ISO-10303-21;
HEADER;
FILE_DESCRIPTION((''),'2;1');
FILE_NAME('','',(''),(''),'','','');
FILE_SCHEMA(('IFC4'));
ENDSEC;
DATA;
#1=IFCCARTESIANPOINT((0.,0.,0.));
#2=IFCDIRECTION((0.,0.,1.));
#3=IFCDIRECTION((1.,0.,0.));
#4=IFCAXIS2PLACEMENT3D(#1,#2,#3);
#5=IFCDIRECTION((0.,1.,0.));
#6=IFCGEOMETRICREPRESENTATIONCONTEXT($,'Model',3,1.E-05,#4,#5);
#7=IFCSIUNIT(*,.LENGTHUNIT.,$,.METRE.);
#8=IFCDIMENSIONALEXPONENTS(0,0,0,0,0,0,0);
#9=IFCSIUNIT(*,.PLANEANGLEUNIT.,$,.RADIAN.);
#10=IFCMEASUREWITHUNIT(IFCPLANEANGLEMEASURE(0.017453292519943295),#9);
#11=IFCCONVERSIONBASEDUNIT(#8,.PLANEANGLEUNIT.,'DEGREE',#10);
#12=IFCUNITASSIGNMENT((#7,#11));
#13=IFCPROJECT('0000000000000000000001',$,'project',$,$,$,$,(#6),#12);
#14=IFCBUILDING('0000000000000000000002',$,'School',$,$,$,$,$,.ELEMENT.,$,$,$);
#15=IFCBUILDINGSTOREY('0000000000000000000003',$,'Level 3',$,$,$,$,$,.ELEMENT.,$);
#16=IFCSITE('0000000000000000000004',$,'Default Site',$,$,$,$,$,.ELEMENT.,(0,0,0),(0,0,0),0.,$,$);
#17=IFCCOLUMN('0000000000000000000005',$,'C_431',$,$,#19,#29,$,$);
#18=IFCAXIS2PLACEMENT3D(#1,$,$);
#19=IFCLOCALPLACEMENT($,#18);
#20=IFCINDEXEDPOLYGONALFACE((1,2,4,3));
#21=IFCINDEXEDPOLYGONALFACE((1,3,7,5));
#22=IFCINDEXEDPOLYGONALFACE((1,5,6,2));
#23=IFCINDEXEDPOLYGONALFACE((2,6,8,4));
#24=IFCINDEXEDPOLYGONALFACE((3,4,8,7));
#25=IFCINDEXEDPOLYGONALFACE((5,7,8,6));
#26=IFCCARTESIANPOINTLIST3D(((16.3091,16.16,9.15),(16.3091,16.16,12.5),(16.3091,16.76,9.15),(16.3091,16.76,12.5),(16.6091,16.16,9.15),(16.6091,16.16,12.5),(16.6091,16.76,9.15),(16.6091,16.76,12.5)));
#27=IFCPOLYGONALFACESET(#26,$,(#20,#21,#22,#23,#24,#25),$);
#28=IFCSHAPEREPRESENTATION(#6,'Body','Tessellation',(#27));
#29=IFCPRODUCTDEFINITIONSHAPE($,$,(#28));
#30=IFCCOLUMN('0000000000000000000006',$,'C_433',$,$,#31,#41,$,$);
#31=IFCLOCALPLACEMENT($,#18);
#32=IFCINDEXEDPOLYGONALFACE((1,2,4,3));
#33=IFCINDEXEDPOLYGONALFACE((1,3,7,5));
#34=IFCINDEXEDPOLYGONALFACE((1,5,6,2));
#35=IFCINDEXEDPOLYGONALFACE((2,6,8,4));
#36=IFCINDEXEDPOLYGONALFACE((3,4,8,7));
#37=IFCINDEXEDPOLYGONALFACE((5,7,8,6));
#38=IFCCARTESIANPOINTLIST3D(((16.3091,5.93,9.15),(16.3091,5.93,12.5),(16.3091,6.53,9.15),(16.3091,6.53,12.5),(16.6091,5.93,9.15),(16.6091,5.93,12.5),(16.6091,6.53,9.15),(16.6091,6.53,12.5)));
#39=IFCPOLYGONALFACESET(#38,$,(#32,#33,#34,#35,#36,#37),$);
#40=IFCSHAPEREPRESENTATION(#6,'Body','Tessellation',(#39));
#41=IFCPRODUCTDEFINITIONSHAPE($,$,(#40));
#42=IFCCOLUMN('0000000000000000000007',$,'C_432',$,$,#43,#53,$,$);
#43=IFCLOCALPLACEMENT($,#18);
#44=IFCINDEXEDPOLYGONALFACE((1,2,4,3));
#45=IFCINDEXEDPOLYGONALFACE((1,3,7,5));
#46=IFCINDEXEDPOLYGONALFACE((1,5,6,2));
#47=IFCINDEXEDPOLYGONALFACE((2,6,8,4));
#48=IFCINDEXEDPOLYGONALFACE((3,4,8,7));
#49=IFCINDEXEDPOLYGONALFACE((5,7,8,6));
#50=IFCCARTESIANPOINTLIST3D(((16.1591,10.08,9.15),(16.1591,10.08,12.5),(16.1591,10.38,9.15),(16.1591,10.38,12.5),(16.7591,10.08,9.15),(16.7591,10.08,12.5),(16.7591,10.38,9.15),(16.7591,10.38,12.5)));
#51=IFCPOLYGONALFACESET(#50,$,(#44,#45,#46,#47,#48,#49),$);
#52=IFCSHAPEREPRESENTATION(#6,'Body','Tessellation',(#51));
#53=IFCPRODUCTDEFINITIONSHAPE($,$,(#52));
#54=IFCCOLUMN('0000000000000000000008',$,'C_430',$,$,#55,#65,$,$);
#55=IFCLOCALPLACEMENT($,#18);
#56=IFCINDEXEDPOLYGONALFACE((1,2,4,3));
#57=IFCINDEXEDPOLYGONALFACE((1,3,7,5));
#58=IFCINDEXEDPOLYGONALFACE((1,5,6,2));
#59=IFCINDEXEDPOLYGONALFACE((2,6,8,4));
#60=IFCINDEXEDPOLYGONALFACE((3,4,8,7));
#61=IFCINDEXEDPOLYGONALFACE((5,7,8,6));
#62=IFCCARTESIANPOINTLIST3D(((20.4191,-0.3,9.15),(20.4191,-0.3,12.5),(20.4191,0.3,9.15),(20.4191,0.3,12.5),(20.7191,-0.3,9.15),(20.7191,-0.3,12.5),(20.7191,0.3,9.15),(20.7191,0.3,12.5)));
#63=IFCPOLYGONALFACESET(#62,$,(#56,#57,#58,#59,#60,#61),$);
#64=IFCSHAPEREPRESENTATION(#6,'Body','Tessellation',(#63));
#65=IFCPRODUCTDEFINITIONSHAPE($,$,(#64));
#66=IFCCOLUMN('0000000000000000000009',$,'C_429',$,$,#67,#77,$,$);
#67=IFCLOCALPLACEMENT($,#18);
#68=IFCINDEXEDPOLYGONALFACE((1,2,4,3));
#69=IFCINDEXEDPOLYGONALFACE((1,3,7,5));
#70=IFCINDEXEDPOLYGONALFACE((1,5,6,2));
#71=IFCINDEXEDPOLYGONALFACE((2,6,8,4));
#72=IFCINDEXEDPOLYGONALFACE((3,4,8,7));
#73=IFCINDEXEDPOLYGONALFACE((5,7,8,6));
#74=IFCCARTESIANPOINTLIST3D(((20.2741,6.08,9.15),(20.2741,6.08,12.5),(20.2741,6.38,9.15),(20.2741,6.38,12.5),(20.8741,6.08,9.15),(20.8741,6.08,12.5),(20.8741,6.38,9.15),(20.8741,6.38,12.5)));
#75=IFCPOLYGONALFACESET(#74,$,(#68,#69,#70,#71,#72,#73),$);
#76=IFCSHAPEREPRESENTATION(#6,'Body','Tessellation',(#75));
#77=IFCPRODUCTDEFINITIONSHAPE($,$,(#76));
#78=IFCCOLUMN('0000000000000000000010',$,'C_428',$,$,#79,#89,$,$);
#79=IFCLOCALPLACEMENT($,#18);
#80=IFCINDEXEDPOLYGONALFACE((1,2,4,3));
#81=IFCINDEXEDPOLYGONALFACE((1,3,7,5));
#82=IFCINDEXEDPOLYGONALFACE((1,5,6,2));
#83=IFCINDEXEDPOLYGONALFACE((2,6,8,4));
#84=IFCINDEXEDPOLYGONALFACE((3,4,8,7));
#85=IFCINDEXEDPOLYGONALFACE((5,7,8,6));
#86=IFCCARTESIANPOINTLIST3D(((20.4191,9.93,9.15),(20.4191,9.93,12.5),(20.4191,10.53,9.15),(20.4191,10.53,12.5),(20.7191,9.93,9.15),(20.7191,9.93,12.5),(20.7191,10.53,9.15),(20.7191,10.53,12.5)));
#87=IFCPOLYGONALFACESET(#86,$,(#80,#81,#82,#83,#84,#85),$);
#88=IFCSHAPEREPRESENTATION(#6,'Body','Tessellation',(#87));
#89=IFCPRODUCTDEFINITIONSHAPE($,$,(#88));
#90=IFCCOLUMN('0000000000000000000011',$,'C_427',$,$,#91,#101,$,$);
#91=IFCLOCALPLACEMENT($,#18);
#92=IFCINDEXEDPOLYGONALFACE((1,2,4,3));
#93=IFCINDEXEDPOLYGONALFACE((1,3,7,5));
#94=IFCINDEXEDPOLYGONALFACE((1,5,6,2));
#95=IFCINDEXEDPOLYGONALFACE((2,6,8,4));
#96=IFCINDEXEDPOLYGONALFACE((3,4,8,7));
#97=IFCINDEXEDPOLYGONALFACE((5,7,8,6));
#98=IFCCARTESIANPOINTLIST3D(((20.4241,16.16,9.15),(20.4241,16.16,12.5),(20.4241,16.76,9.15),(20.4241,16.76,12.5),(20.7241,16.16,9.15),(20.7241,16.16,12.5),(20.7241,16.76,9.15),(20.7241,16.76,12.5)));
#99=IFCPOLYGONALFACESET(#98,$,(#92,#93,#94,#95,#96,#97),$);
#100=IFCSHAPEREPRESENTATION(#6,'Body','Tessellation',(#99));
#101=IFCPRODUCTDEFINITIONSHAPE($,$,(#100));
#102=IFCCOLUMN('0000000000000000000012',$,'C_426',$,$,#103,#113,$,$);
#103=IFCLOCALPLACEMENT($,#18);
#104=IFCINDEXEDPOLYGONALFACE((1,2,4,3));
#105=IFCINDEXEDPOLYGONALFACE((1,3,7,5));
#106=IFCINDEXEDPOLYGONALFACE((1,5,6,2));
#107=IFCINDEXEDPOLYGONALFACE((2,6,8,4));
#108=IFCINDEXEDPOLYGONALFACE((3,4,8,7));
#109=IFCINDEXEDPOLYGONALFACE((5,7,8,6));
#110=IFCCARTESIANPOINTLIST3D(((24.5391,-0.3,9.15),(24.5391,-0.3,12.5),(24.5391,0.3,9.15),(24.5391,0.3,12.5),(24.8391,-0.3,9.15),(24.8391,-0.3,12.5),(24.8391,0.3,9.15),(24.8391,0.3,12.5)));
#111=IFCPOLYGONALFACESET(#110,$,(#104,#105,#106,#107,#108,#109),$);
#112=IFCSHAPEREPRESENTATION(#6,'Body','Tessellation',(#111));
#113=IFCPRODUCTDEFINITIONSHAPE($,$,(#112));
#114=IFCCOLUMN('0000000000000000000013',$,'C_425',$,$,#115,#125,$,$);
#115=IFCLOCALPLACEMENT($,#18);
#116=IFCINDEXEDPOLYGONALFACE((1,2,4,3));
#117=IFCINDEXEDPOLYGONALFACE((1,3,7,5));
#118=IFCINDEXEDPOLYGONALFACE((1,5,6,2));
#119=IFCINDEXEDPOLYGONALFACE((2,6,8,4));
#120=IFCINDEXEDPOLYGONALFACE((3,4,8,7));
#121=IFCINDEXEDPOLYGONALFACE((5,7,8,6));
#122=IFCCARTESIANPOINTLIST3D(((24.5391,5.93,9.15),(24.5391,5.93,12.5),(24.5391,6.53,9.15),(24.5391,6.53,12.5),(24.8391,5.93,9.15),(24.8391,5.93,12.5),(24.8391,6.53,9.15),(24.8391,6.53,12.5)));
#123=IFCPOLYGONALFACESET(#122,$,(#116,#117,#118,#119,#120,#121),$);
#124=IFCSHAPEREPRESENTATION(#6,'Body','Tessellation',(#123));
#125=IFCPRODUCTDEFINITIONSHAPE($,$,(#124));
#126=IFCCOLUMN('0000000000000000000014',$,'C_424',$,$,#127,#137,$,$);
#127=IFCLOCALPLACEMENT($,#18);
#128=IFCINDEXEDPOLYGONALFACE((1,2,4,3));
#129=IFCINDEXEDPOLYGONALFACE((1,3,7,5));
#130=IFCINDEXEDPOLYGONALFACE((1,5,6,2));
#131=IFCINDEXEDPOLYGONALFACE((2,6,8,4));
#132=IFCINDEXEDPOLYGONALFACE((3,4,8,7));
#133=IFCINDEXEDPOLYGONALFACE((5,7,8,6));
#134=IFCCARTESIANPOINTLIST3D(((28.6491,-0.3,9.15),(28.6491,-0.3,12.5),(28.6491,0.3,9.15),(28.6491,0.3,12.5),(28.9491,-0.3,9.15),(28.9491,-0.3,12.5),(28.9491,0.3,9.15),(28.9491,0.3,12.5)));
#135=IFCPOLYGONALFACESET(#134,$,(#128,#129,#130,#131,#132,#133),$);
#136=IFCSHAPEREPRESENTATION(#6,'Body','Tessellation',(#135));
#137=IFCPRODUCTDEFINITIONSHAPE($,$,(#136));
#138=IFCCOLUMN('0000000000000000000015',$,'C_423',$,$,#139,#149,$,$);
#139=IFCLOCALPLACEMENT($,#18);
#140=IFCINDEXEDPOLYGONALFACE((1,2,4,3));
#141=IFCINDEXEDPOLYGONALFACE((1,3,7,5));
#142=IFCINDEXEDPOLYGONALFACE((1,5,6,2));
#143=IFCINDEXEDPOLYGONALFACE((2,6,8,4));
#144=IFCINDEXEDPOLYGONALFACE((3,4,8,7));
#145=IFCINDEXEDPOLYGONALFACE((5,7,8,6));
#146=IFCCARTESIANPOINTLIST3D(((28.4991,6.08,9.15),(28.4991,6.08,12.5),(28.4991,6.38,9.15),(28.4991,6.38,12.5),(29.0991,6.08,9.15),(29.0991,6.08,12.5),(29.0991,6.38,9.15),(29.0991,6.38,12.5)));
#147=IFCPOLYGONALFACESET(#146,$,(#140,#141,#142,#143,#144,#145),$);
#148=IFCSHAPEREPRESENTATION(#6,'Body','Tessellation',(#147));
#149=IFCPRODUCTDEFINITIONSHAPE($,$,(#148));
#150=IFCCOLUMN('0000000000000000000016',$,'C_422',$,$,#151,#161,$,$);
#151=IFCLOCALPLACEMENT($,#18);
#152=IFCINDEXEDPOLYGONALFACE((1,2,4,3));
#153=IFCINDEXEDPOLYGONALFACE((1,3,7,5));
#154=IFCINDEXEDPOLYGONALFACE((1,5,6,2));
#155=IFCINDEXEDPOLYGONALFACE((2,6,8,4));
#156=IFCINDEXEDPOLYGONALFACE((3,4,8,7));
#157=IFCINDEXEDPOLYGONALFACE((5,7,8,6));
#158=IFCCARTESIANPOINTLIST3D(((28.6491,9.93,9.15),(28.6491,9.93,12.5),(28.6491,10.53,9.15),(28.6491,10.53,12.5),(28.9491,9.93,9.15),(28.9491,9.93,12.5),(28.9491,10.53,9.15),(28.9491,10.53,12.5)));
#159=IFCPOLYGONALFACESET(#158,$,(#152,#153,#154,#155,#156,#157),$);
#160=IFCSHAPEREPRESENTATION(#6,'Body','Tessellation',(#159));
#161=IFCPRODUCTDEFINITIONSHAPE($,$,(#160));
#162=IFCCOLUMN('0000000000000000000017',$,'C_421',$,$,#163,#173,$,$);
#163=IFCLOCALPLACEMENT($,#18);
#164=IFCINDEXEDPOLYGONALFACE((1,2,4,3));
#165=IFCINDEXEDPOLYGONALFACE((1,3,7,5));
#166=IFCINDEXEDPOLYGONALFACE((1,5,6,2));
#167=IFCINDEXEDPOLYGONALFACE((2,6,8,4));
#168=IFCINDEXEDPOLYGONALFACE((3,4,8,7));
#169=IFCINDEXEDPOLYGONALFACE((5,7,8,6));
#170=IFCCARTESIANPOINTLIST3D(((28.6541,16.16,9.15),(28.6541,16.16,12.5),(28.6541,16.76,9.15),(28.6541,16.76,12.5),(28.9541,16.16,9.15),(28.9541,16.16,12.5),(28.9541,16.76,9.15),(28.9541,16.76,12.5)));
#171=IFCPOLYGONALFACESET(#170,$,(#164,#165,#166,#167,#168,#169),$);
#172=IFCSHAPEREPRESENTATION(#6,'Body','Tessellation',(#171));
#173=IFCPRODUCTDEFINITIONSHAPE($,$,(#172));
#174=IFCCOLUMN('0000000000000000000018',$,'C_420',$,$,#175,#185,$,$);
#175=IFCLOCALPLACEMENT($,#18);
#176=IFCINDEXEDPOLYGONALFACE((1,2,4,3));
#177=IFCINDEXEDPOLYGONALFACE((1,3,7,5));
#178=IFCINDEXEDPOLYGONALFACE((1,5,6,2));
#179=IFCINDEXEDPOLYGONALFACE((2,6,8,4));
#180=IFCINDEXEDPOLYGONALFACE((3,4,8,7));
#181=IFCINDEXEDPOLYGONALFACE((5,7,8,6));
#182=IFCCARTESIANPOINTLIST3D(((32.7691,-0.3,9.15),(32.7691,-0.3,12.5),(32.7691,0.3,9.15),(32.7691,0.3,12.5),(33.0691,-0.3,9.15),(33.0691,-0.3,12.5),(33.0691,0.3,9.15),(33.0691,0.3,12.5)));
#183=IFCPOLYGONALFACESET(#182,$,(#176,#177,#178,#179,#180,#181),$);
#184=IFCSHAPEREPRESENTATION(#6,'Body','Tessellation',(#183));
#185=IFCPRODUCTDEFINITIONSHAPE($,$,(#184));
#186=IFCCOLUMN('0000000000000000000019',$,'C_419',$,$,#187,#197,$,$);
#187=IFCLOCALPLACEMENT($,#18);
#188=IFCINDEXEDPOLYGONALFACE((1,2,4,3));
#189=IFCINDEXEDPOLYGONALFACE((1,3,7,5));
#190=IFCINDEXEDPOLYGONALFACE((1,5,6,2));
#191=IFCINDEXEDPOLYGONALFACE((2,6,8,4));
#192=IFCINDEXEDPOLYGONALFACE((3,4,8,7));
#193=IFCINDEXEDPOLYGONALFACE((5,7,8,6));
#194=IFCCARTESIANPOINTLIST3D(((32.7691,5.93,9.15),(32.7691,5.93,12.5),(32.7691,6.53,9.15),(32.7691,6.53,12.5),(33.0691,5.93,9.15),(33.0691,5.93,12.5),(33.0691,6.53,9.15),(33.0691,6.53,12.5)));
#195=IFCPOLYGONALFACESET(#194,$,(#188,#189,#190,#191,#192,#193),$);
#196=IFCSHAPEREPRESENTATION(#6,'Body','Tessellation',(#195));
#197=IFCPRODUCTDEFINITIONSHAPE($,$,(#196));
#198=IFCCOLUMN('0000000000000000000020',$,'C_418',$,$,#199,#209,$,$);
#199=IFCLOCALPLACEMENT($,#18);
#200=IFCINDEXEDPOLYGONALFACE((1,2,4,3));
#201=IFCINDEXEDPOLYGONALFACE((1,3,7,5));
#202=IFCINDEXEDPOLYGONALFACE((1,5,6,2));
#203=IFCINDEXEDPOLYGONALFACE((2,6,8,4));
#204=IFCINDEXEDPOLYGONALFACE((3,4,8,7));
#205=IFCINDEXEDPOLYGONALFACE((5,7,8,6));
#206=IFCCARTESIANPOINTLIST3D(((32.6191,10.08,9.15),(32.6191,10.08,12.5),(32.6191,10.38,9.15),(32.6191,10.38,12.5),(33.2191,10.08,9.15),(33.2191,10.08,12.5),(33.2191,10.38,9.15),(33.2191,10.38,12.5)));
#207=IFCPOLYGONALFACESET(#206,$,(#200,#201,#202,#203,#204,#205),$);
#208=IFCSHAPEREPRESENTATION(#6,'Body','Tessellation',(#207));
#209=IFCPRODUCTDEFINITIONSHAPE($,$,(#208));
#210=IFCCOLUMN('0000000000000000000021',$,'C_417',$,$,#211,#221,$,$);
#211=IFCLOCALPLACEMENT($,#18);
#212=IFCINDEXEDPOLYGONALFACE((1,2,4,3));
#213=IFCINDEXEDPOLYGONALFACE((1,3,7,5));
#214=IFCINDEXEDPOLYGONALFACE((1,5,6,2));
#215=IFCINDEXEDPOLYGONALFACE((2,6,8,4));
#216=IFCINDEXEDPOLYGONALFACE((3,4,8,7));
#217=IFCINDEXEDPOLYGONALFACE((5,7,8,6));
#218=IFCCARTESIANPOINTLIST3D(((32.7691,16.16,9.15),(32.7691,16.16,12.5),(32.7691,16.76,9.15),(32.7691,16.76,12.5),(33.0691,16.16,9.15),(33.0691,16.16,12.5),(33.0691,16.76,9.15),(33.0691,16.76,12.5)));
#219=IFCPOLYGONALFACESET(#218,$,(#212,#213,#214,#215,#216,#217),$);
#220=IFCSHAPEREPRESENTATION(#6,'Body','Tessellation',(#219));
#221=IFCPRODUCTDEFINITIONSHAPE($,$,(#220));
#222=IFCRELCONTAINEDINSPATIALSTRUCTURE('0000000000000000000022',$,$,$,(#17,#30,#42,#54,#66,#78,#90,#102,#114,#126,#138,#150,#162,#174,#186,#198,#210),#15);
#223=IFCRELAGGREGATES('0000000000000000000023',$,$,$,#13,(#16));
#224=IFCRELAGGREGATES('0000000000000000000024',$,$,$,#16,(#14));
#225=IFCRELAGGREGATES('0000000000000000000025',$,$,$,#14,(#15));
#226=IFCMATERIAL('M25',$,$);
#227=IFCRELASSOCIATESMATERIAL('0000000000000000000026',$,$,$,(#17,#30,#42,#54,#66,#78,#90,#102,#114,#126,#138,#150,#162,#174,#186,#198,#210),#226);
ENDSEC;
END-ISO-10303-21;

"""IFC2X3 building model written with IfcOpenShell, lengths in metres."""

from ifc_helpers import new_model, entity, si_unit, converted_unit, direction, frame, frame_2d, origin_with_axes, place, context, project, spatial, rectangle, extrude, material, element, save


model = new_model("IFC2X3")

# Units and contexts
model_context = context("Model", 3, precision=1e-05, world=origin_with_axes(), true_north=direction((0.0, 1.0, 0.0)))
ifc_project = project(units=[si_unit("LENGTHUNIT", "METRE"), converted_unit("PLANEANGLEUNIT", "DEGREE", entity("IfcPlaneAngleMeasure", 0.017453292519943295), si_unit("PLANEANGLEUNIT", "RADIAN"), dimensions=[0, 0, 0, 0, 0, 0, 0])], contexts=[model_context])

# Site, building, storey
site = spatial("IfcSite", under=ifc_project, Name="Default Site", CompositionType="ELEMENT", RefLatitude=(0, 0, 0), RefLongitude=(0, 0, 0), RefElevation=0.0)
building = spatial("IfcBuilding", under=site, Name="School", CompositionType="ELEMENT")
storey = spatial("IfcBuildingStorey", under=building, Name="Level 3", CompositionType="ELEMENT")

# Columns
ifc_material = material(Name="M25")
placement = place(None, origin_with_axes())
element("IfcColumn", 1, at=placement, inside=storey, material=ifc_material, Name="C_431", context=model_context, shape_type="SweptSolid", body=[
    extrude(rectangle(XDim=0.3, YDim=0.6, at=frame_2d((0.0, 0.0), x_axis=(1.0, 0.0, 0.0))), frame((16.4591, 16.46, 9.15), z_axis=(0.0, 0.0, 1.0), x_axis=(1.0, 0.0, 0.0)), (0.0, 0.0, 1.0), 3.35),
])
element("IfcColumn", 2, at=placement, inside=storey, material=ifc_material, Name="C_433", context=model_context, shape_type="SweptSolid", body=[
    extrude(rectangle(XDim=0.3, YDim=0.6, at=frame_2d((0.0, 0.0), x_axis=(1.0, 0.0, 0.0))), frame((16.4591, 6.23, 9.15), z_axis=(0.0, 0.0, 1.0), x_axis=(1.0, 0.0, 0.0)), (0.0, 0.0, 1.0), 3.35),
])
element("IfcColumn", 3, at=placement, inside=storey, material=ifc_material, Name="C_432", context=model_context, shape_type="SweptSolid", body=[
    extrude(rectangle(XDim=0.6, YDim=0.3, at=frame_2d((0.0, 0.0), x_axis=(1.0, 0.0, 0.0))), frame((16.4591, 10.23, 9.15), z_axis=(0.0, 0.0, 1.0), x_axis=(1.0, 0.0, 0.0)), (0.0, 0.0, 1.0), 3.35),
])
element("IfcColumn", 4, at=placement, inside=storey, material=ifc_material, Name="C_430", context=model_context, shape_type="SweptSolid", body=[
    extrude(rectangle(XDim=0.3, YDim=0.6, at=frame_2d((0.0, 0.0), x_axis=(1.0, 0.0, 0.0))), frame((20.5691, 0.0, 9.15), z_axis=(0.0, 0.0, 1.0), x_axis=(1.0, 0.0, 0.0)), (0.0, 0.0, 1.0), 3.35),
])
element("IfcColumn", 5, at=placement, inside=storey, material=ifc_material, Name="C_429", context=model_context, shape_type="SweptSolid", body=[
    extrude(rectangle(XDim=0.6, YDim=0.3, at=frame_2d((0.0, 0.0), x_axis=(1.0, 0.0, 0.0))), frame((20.5741, 6.23, 9.15), z_axis=(0.0, 0.0, 1.0), x_axis=(1.0, 0.0, 0.0)), (0.0, 0.0, 1.0), 3.35),
])
element("IfcColumn", 6, at=placement, inside=storey, material=ifc_material, Name="C_428", context=model_context, shape_type="SweptSolid", body=[
    extrude(rectangle(XDim=0.3, YDim=0.6, at=frame_2d((0.0, 0.0), x_axis=(1.0, 0.0, 0.0))), frame((20.5691, 10.23, 9.15), z_axis=(0.0, 0.0, 1.0), x_axis=(1.0, 0.0, 0.0)), (0.0, 0.0, 1.0), 3.35),
])
element("IfcColumn", 7, at=placement, inside=storey, material=ifc_material, Name="C_427", context=model_context, shape_type="SweptSolid", body=[
    extrude(rectangle(XDim=0.3, YDim=0.6, at=frame_2d((0.0, 0.0), x_axis=(1.0, 0.0, 0.0))), frame((20.5741, 16.46, 9.15), z_axis=(0.0, 0.0, 1.0), x_axis=(1.0, 0.0, 0.0)), (0.0, 0.0, 1.0), 3.35),
])
element("IfcColumn", 8, at=placement, inside=storey, material=ifc_material, Name="C_426", context=model_context, shape_type="SweptSolid", body=[
    extrude(rectangle(XDim=0.3, YDim=0.6, at=frame_2d((0.0, 0.0), x_axis=(1.0, 0.0, 0.0))), frame((24.6891, 0.0, 9.15), z_axis=(0.0, 0.0, 1.0), x_axis=(1.0, 0.0, 0.0)), (0.0, 0.0, 1.0), 3.35),
])
element("IfcColumn", 9, at=placement, inside=storey, material=ifc_material, Name="C_425", context=model_context, shape_type="SweptSolid", body=[
    extrude(rectangle(XDim=0.3, YDim=0.6, at=frame_2d((0.0, 0.0), x_axis=(1.0, 0.0, 0.0))), frame((24.6891, 6.23, 9.15), z_axis=(0.0, 0.0, 1.0), x_axis=(1.0, 0.0, 0.0)), (0.0, 0.0, 1.0), 3.35),
])
element("IfcColumn", 10, at=placement, inside=storey, material=ifc_material, Name="C_424", context=model_context, shape_type="SweptSolid", body=[
    extrude(rectangle(XDim=0.3, YDim=0.6, at=frame_2d((0.0, 0.0), x_axis=(1.0, 0.0, 0.0))), frame((28.7991, 0.0, 9.15), z_axis=(0.0, 0.0, 1.0), x_axis=(1.0, 0.0, 0.0)), (0.0, 0.0, 1.0), 3.35),
])
element("IfcColumn", 11, at=placement, inside=storey, material=ifc_material, Name="C_423", context=model_context, shape_type="SweptSolid", body=[
    extrude(rectangle(XDim=0.6, YDim=0.3, at=frame_2d((0.0, 0.0), x_axis=(1.0, 0.0, 0.0))), frame((28.7991, 6.23, 9.15), z_axis=(0.0, 0.0, 1.0), x_axis=(1.0, 0.0, 0.0)), (0.0, 0.0, 1.0), 3.35),
])
element("IfcColumn", 12, at=placement, inside=storey, material=ifc_material, Name="C_422", context=model_context, shape_type="SweptSolid", body=[
    extrude(rectangle(XDim=0.3, YDim=0.6, at=frame_2d((0.0, 0.0), x_axis=(1.0, 0.0, 0.0))), frame((28.7991, 10.23, 9.15), z_axis=(0.0, 0.0, 1.0), x_axis=(1.0, 0.0, 0.0)), (0.0, 0.0, 1.0), 3.35),
])
element("IfcColumn", 13, at=placement, inside=storey, material=ifc_material, Name="C_421", context=model_context, shape_type="SweptSolid", body=[
    extrude(rectangle(XDim=0.3, YDim=0.6, at=frame_2d((0.0, 0.0), x_axis=(1.0, 0.0, 0.0))), frame((28.8041, 16.46, 9.15), z_axis=(0.0, 0.0, 1.0), x_axis=(1.0, 0.0, 0.0)), (0.0, 0.0, 1.0), 3.35),
])
element("IfcColumn", 14, at=placement, inside=storey, material=ifc_material, Name="C_420", context=model_context, shape_type="SweptSolid", body=[
    extrude(rectangle(XDim=0.3, YDim=0.6, at=frame_2d((0.0, 0.0), x_axis=(1.0, 0.0, 0.0))), frame((32.9191, 0.0, 9.15), z_axis=(0.0, 0.0, 1.0), x_axis=(1.0, 0.0, 0.0)), (0.0, 0.0, 1.0), 3.35),
])
element("IfcColumn", 15, at=placement, inside=storey, material=ifc_material, Name="C_419", context=model_context, shape_type="SweptSolid", body=[
    extrude(rectangle(XDim=0.3, YDim=0.6, at=frame_2d((0.0, 0.0), x_axis=(1.0, 0.0, 0.0))), frame((32.9191, 6.23, 9.15), z_axis=(0.0, 0.0, 1.0), x_axis=(1.0, 0.0, 0.0)), (0.0, 0.0, 1.0), 3.35),
])
element("IfcColumn", 16, at=placement, inside=storey, material=ifc_material, Name="C_418", context=model_context, shape_type="SweptSolid", body=[
    extrude(rectangle(XDim=0.6, YDim=0.3, at=frame_2d((0.0, 0.0), x_axis=(1.0, 0.0, 0.0))), frame((32.9191, 10.23, 9.15), z_axis=(0.0, 0.0, 1.0), x_axis=(1.0, 0.0, 0.0)), (0.0, 0.0, 1.0), 3.35),
])
element("IfcColumn", 17, at=placement, inside=storey, material=ifc_material, Name="C_417", context=model_context, shape_type="SweptSolid", body=[
    extrude(rectangle(XDim=0.3, YDim=0.6, at=frame_2d((0.0, 0.0), x_axis=(1.0, 0.0, 0.0))), frame((32.9191, 16.46, 9.15), z_axis=(0.0, 0.0, 1.0), x_axis=(1.0, 0.0, 0.0)), (0.0, 0.0, 1.0), 3.35),
])

save(model, "model.ifc")
